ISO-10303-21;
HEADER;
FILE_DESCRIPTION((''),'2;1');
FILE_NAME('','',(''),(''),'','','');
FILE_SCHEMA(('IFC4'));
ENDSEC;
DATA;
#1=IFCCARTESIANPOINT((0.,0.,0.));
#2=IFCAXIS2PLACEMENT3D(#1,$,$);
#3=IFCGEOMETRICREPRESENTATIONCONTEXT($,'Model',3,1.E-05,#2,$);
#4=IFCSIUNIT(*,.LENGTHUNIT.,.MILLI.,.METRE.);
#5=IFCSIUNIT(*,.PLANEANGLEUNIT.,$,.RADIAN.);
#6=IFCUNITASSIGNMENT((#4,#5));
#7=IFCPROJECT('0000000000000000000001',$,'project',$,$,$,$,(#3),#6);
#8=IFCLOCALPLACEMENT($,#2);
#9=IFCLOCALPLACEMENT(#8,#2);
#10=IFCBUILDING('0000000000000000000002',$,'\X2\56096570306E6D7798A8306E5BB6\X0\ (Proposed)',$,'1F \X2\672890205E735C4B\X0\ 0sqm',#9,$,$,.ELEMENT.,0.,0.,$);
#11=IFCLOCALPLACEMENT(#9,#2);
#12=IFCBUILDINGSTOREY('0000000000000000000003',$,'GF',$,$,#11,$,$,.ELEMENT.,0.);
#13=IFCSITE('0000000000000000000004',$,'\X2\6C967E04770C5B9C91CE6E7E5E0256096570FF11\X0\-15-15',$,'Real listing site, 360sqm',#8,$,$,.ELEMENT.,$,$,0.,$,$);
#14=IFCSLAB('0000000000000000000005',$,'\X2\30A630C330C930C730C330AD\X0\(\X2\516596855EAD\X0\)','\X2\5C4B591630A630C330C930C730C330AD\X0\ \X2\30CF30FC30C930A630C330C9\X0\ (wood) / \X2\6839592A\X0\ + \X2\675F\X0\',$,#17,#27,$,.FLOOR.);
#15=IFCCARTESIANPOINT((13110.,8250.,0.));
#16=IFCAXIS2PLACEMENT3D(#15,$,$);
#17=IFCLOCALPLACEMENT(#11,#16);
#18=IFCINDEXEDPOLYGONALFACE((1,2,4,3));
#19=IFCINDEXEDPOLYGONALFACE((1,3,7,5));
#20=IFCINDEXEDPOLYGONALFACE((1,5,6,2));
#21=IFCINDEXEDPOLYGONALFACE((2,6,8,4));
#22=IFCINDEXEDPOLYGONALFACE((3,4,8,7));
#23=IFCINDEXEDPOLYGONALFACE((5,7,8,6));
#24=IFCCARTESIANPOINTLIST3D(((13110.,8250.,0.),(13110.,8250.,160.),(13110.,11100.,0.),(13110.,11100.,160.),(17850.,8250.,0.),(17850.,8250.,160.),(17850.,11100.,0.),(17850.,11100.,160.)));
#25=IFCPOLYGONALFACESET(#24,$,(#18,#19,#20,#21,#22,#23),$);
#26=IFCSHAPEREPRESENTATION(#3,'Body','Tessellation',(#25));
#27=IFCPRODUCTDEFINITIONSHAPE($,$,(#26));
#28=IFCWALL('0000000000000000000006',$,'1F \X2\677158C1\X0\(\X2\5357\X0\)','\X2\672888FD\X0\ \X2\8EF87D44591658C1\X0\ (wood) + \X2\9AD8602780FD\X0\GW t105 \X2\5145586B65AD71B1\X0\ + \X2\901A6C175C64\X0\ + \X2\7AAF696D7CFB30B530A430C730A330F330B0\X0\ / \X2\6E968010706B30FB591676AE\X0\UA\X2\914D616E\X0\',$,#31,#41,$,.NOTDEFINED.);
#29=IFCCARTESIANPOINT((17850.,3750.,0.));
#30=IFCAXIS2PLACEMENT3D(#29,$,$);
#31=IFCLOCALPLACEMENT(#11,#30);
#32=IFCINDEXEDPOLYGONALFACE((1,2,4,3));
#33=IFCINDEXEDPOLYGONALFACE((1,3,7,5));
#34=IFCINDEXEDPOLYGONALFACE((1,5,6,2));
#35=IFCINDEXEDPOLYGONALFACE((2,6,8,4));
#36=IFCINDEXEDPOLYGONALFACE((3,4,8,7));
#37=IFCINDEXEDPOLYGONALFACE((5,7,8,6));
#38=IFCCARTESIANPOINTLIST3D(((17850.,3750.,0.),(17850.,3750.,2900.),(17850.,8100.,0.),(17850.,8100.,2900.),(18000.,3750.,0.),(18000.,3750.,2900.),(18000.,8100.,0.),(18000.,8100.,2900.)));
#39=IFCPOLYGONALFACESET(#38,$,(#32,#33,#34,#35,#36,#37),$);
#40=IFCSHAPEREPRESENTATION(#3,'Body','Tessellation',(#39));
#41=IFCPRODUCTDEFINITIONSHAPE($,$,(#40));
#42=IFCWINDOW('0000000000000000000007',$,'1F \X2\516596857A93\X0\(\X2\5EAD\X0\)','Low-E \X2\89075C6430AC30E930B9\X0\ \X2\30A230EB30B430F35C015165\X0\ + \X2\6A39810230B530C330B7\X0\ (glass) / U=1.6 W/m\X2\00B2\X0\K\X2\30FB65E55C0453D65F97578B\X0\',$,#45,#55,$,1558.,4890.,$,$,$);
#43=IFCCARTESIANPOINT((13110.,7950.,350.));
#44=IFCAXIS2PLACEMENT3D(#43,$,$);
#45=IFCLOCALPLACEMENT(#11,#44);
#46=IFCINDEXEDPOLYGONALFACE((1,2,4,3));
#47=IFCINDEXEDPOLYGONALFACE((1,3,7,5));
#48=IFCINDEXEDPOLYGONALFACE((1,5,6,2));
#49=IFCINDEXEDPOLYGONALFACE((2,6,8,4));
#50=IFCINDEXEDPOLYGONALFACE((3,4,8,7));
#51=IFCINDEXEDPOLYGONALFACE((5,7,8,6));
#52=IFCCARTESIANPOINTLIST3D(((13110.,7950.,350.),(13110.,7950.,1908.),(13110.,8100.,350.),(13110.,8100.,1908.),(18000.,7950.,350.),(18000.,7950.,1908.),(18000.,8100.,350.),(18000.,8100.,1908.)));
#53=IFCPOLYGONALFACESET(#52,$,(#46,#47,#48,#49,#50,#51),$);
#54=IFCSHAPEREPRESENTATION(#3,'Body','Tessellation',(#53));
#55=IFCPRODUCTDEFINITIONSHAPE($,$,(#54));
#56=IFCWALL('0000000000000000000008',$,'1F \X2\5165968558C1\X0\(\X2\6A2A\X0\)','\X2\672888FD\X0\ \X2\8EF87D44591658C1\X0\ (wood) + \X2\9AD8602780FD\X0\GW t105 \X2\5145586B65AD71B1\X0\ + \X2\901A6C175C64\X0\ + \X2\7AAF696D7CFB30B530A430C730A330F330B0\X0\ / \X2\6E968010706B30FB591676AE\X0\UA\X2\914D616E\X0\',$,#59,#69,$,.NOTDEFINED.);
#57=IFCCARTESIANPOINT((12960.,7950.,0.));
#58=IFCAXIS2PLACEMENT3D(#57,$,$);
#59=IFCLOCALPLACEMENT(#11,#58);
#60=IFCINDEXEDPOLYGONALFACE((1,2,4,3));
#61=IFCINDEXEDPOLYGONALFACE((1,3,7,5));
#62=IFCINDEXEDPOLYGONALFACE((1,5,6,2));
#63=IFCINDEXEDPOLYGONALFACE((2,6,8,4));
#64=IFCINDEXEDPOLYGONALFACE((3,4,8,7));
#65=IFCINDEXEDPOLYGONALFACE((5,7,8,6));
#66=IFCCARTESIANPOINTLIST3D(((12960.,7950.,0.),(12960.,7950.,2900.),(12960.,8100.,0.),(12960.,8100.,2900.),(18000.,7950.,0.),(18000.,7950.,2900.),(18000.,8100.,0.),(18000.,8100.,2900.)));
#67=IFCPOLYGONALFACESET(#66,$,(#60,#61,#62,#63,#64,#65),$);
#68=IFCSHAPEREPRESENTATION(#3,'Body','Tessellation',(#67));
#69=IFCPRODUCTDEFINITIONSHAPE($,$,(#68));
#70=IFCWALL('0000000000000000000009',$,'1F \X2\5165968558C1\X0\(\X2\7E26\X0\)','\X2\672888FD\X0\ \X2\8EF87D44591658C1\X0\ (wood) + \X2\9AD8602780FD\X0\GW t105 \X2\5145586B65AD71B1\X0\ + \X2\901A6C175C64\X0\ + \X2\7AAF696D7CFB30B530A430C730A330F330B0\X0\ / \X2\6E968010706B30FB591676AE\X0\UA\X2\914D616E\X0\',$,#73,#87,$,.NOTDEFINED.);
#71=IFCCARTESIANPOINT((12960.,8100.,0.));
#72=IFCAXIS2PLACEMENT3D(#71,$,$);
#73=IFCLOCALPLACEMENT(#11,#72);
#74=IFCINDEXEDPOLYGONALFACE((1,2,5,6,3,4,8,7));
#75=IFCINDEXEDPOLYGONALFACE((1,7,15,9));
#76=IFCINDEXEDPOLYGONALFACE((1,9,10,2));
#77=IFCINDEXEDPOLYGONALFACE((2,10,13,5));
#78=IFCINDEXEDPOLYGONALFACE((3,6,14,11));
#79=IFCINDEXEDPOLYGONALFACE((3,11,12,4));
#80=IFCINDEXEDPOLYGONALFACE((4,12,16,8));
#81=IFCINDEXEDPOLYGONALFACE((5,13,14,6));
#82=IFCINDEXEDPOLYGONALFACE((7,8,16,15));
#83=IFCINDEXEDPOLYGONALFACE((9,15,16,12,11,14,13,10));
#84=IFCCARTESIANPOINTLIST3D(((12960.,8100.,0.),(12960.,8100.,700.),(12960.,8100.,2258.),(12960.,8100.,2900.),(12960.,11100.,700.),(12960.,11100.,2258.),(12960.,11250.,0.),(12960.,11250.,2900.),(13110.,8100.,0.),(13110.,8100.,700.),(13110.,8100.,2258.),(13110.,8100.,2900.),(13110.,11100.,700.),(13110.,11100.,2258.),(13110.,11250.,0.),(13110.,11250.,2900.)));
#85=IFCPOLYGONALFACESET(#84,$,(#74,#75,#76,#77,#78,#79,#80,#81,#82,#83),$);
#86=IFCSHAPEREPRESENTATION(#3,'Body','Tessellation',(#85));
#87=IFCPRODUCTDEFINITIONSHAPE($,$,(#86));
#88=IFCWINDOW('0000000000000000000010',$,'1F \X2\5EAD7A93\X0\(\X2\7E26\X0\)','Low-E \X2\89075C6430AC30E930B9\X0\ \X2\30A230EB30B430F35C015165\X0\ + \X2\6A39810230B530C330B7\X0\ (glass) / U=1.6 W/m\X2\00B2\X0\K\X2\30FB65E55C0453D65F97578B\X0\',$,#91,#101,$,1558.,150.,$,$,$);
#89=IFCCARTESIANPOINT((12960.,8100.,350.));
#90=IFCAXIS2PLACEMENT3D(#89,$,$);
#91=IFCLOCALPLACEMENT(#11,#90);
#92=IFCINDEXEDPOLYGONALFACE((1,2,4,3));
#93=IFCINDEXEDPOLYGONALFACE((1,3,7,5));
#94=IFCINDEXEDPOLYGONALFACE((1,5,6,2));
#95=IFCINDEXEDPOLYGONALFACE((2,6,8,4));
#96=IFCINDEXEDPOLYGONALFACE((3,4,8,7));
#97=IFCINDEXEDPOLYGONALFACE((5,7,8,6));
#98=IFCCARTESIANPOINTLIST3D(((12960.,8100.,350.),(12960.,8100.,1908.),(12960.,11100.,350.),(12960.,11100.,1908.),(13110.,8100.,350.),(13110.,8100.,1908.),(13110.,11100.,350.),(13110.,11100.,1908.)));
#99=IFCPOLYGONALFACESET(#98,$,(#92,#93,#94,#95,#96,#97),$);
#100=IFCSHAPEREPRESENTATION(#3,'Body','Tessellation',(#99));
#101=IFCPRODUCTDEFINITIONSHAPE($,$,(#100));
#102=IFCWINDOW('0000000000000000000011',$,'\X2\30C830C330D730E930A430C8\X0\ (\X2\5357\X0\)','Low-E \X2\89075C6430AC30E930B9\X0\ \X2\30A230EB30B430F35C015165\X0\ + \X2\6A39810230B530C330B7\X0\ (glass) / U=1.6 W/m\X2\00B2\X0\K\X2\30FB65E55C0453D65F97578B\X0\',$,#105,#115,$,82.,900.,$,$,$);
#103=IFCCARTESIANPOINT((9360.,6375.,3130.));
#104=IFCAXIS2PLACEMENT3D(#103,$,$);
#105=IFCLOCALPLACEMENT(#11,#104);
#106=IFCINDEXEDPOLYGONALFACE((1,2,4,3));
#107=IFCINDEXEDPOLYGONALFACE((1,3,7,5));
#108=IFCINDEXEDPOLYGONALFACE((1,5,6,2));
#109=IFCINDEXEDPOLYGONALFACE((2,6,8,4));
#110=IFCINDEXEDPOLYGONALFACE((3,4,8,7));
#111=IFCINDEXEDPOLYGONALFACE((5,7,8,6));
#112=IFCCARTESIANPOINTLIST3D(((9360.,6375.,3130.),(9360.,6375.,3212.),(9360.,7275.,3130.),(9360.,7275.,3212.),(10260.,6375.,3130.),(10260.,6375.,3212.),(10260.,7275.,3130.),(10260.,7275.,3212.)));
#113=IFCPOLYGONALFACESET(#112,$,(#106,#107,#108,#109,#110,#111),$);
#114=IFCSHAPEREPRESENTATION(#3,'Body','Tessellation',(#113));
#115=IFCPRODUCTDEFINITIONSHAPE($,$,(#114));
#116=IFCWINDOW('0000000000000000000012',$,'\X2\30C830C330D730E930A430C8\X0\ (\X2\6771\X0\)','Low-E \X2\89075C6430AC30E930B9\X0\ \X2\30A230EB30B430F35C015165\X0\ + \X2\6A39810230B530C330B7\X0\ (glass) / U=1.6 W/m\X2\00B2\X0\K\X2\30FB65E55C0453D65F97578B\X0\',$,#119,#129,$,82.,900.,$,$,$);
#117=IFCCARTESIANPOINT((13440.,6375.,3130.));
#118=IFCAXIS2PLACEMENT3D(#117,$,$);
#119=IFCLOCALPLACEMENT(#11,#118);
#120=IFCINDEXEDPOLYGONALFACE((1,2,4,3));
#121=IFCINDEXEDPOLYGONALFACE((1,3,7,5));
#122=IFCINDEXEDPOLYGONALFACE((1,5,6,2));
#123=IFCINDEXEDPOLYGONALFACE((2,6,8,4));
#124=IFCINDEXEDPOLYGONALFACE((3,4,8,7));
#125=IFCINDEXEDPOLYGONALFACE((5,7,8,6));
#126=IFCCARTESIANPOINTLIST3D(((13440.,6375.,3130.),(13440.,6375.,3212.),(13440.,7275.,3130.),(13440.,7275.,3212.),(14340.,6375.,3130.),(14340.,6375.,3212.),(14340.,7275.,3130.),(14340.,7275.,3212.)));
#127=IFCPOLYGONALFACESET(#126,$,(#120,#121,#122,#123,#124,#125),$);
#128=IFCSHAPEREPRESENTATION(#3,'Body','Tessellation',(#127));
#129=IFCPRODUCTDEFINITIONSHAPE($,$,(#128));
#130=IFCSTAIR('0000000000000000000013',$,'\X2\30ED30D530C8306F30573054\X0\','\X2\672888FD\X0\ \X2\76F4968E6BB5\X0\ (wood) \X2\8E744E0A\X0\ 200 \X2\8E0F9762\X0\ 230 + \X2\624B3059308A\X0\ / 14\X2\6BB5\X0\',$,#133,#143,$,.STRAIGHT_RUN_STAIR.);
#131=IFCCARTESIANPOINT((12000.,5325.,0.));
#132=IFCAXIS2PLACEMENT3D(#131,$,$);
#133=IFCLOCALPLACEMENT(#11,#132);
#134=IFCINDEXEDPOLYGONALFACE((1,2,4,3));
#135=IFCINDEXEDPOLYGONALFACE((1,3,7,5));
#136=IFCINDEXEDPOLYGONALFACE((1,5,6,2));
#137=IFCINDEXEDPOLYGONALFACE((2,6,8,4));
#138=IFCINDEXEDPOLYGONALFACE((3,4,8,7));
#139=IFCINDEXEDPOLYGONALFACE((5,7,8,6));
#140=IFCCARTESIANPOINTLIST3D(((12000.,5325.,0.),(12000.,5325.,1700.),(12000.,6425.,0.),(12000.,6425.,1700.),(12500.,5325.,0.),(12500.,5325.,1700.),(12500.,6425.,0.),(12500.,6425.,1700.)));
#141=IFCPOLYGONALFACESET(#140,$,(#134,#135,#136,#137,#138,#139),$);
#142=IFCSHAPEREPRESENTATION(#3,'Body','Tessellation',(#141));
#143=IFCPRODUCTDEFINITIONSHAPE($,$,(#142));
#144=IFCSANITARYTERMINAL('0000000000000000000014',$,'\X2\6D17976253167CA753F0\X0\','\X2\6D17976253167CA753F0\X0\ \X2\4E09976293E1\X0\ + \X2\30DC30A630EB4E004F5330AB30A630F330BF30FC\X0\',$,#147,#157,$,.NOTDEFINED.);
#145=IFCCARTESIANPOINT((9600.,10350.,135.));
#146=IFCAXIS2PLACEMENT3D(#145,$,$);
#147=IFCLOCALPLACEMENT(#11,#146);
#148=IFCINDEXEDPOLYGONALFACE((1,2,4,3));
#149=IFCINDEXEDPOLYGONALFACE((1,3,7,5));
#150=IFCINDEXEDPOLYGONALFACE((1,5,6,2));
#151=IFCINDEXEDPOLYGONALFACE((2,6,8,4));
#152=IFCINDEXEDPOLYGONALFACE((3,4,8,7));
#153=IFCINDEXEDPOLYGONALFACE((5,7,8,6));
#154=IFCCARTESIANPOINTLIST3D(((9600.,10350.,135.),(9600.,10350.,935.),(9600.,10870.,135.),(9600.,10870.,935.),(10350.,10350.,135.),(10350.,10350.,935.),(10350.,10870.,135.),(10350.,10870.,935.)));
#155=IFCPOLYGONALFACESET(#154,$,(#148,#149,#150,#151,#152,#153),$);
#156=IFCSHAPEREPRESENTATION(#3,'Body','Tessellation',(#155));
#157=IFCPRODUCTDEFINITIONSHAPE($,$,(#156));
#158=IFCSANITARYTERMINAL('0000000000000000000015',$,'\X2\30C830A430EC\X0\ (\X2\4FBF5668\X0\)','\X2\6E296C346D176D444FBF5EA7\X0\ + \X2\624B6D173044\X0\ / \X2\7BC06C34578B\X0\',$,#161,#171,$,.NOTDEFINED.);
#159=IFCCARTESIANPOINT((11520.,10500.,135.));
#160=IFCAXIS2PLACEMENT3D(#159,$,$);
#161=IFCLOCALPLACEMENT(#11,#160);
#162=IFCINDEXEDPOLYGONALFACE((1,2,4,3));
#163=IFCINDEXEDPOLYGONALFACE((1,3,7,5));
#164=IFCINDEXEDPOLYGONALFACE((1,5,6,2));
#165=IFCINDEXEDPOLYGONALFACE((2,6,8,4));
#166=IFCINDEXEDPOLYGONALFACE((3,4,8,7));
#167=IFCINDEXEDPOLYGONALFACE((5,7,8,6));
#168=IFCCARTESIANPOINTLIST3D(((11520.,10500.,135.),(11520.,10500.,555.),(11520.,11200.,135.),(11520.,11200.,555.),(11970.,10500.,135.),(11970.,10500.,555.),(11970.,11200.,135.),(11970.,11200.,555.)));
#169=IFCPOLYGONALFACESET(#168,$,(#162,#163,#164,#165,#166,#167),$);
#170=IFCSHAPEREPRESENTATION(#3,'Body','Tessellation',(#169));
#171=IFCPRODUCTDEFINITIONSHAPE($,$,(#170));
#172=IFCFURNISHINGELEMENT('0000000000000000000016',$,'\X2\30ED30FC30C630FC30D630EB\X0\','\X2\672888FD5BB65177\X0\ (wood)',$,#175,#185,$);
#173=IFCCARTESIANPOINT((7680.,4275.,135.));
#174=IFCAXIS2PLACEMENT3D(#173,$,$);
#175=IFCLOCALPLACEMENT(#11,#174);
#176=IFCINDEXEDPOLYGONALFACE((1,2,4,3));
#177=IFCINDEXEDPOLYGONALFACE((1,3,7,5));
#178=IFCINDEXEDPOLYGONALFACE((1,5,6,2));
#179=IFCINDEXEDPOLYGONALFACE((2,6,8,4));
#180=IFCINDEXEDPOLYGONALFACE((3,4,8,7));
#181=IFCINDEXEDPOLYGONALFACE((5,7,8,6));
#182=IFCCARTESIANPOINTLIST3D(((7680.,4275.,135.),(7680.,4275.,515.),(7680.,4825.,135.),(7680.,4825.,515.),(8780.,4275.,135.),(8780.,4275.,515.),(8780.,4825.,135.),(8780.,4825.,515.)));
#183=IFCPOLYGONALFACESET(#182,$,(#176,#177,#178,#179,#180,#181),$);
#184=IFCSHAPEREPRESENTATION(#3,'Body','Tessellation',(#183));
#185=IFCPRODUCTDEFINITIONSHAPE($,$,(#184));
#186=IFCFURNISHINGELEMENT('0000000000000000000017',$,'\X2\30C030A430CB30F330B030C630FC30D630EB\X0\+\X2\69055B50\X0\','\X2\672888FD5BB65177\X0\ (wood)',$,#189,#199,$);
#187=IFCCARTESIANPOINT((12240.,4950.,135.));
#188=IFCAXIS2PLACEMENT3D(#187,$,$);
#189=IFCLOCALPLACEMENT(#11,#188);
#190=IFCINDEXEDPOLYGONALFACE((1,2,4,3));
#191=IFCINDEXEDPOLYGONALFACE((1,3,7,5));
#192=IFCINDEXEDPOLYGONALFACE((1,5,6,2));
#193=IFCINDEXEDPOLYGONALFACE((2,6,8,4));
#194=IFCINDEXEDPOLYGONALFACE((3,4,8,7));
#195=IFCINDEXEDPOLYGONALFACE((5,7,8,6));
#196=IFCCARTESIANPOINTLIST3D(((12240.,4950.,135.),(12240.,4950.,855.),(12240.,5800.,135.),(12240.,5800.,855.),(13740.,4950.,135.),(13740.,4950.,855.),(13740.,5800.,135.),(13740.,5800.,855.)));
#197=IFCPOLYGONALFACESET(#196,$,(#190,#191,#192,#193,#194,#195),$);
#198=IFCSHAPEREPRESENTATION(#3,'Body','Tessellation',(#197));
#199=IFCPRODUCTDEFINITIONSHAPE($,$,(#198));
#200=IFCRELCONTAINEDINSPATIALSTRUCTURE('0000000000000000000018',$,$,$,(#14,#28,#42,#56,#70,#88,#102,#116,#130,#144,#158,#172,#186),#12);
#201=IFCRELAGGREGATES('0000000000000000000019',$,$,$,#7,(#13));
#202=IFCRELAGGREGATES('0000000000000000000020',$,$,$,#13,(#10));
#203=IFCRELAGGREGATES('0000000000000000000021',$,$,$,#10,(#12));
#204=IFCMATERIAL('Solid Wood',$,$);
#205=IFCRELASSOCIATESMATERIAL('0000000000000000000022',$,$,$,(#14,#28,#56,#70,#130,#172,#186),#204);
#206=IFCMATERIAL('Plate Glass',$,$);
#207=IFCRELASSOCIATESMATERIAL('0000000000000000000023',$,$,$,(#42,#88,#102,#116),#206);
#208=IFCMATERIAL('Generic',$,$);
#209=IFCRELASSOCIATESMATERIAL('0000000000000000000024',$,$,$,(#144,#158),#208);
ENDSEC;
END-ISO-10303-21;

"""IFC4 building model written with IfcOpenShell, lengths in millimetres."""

from ifc_helpers import new_model, si_unit, frame, frame_2d, origin, place, context, project, spatial, rectangle, extrude, material, element, fill, save


model = new_model("IFC4")

# Units and contexts
model_context = context("Model", 3, precision=1e-05, world=origin())
ifc_project = project(units=[si_unit("LENGTHUNIT", "METRE", prefix="MILLI"), si_unit("PLANEANGLEUNIT", "RADIAN")], contexts=[model_context])

# Site, building, storey
site_placement = place(None, origin())
site = spatial("IfcSite", under=ifc_project, at=site_placement, Name="沖縄県宜野湾市嘉数１-15-15", ObjectType="Real listing site, 360sqm", CompositionType="ELEMENT", RefElevation=0.0)
building_placement = place(site_placement, origin())
building = spatial("IfcBuilding", under=site, at=building_placement, Name="嘉数の海風の家 (Proposed)", ObjectType="1F 木造平屋 0sqm", CompositionType="ELEMENT", ElevationOfRefHeight=0.0, ElevationOfTerrain=0.0)
storey_placement = place(building_placement, origin())
storey = spatial("IfcBuildingStorey", under=building, at=storey_placement, Name="GF", CompositionType="ELEMENT", Elevation=0.0)

# Slab
ifc_material_1 = material(Name="Solid Wood")
slab_placement = place(storey_placement, frame((13110.0, 8250.0, 0.0)))
element("IfcSlab", 1, at=slab_placement, inside=storey, material=ifc_material_1, Name="ウッドデッキ(入隅庭)", Description="屋外ウッドデッキ ハードウッド (wood) / 根太 + 束", PredefinedType="FLOOR", context=model_context, shape_type="SweptSolid", body=[
    extrude(rectangle(XDim=4740.0, YDim=2850.0, at=frame_2d((2370.0, 1425.0))), frame((13110.0, 8250.0, 0.0)), (0.0, 0.0, 1.0), 160.0),
])

# Wall, opening, window
wall_1_placement = place(storey_placement, frame((17850.0, 3750.0, 0.0)))
wall_1 = element("IfcWall", 2, at=wall_1_placement, inside=storey, material=ifc_material_1, Name="1F 東壁(南)", Description="木製 軸組外壁 (wood) + 高性能GW t105 充填断熱 + 通気層 + 窯業系サイディング / 準耐火・外皮UA配慮", PredefinedType="NOTDEFINED", context=model_context, shape_type="SweptSolid", body=[
    extrude(rectangle(XDim=150.0, YDim=4350.0, at=frame_2d((75.0, 2175.0))), frame((17850.0, 3750.0, 0.0)), (0.0, 0.0, 1.0), 2900.0),
])
opening_1_placement = place(storey_placement, frame((13110.0, 7950.0, 350.0)))
opening_1 = element("IfcOpeningElement", 3, at=opening_1_placement, cuts=wall_1, PredefinedType="NOTDEFINED", context=model_context, shape_type="SweptSolid", body=[
    extrude(rectangle(XDim=4890.0, YDim=150.0, at=frame_2d((2445.0, 75.0))), frame((13110.0, 7950.0, 350.0)), (0.0, 0.0, 1.0), 1558.0),
])
ifc_material_2 = material(Name="Plate Glass")
window_1_placement = place(storey_placement, frame((13110.0, 7950.0, 350.0)))
window_1 = element("IfcWindow", 4, at=window_1_placement, inside=storey, material=ifc_material_2, Name="1F 入隅窓(庭)", Description="Low-E 複層ガラス アルゴン封入 + 樹脂サッシ (glass) / U=1.6 W/m²K・日射取得型", OverallHeight=1558.0, OverallWidth=4890.0, context=model_context, shape_type="SweptSolid", body=[
    extrude(rectangle(XDim=4890.0, YDim=150.0, at=frame_2d((2445.0, 75.0))), frame((13110.0, 7950.0, 350.0)), (0.0, 0.0, 1.0), 1558.0),
])
fill(opening_1, window_1)

# Wall
wall_2_placement = place(storey_placement, frame((12960.0, 7950.0, 0.0)))
element("IfcWall", 5, at=wall_2_placement, inside=storey, material=ifc_material_1, Name="1F 入隅壁(横)", Description="木製 軸組外壁 (wood) + 高性能GW t105 充填断熱 + 通気層 + 窯業系サイディング / 準耐火・外皮UA配慮", PredefinedType="NOTDEFINED", context=model_context, shape_type="SweptSolid", body=[
    extrude(rectangle(XDim=5040.0, YDim=150.0, at=frame_2d((2520.0, 75.0))), frame((12960.0, 7950.0, 0.0)), (0.0, 0.0, 1.0), 2900.0),
])

# Wall, opening, window
wall_3_placement = place(storey_placement, frame((12960.0, 8100.0, 0.0)))
wall_3 = element("IfcWall", 6, at=wall_3_placement, inside=storey, material=ifc_material_1, Name="1F 入隅壁(縦)", Description="木製 軸組外壁 (wood) + 高性能GW t105 充填断熱 + 通気層 + 窯業系サイディング / 準耐火・外皮UA配慮", PredefinedType="NOTDEFINED", context=model_context, shape_type="SweptSolid", body=[
    extrude(rectangle(XDim=150.0, YDim=3150.0, at=frame_2d((75.0, 1575.0))), frame((12960.0, 8100.0, 0.0)), (0.0, 0.0, 1.0), 2900.0),
])
opening_2_placement = place(storey_placement, frame((12960.0, 8100.0, 350.0)))
opening_2 = element("IfcOpeningElement", 7, at=opening_2_placement, cuts=wall_3, PredefinedType="NOTDEFINED", context=model_context, shape_type="SweptSolid", body=[
    extrude(rectangle(XDim=150.0, YDim=3000.0, at=frame_2d((75.0, 1500.0))), frame((12960.0, 8100.0, 350.0)), (0.0, 0.0, 1.0), 1558.0),
])
window_2_placement = place(storey_placement, frame((12960.0, 8100.0, 350.0)))
window_2 = element("IfcWindow", 8, at=window_2_placement, inside=storey, material=ifc_material_2, Name="1F 庭窓(縦)", Description="Low-E 複層ガラス アルゴン封入 + 樹脂サッシ (glass) / U=1.6 W/m²K・日射取得型", OverallHeight=1558.0, OverallWidth=150.0, context=model_context, shape_type="SweptSolid", body=[
    extrude(rectangle(XDim=150.0, YDim=3000.0, at=frame_2d((75.0, 1500.0))), frame((12960.0, 8100.0, 350.0)), (0.0, 0.0, 1.0), 1558.0),
])
fill(opening_2, window_2)

# Windows
window_3_placement = place(storey_placement, frame((9360.0, 6375.0, 3130.0)))
element("IfcWindow", 9, at=window_3_placement, inside=storey, material=ifc_material_2, Name="トップライト (南)", Description="Low-E 複層ガラス アルゴン封入 + 樹脂サッシ (glass) / U=1.6 W/m²K・日射取得型", OverallHeight=82.0, OverallWidth=900.0, context=model_context, shape_type="SweptSolid", body=[
    extrude(rectangle(XDim=900.0, YDim=900.0, at=frame_2d((450.0, 450.0))), frame((9360.0, 6375.0, 3130.0)), (0.0, 0.0, 1.0), 82.0),
])
window_4_placement = place(storey_placement, frame((13440.0, 6375.0, 3130.0)))
element("IfcWindow", 10, at=window_4_placement, inside=storey, material=ifc_material_2, Name="トップライト (東)", Description="Low-E 複層ガラス アルゴン封入 + 樹脂サッシ (glass) / U=1.6 W/m²K・日射取得型", OverallHeight=82.0, OverallWidth=900.0, context=model_context, shape_type="SweptSolid", body=[
    extrude(rectangle(XDim=900.0, YDim=900.0, at=frame_2d((450.0, 450.0))), frame((13440.0, 6375.0, 3130.0)), (0.0, 0.0, 1.0), 82.0),
])

# Stair
stair_placement = place(storey_placement, frame((12000.0, 5325.0, 0.0)))
element("IfcStair", 11, at=stair_placement, inside=storey, material=ifc_material_1, Name="ロフトはしご", Description="木製 直階段 (wood) 蹴上 200 踏面 230 + 手すり / 14段", PredefinedType="STRAIGHT_RUN_STAIR", context=model_context, shape_type="SweptSolid", body=[
    extrude(rectangle(XDim=500.0, YDim=1100.0, at=frame_2d((250.0, 550.0))), frame((12000.0, 5325.0, 0.0)), (0.0, 0.0, 1.0), 1700.0),
])

# Sanitary terminals
ifc_material_3 = material(Name="Generic")
sanitary_terminal_1_placement = place(storey_placement, frame((9600.0, 10350.0, 135.0)))
element("IfcSanitaryTerminal", 12, at=sanitary_terminal_1_placement, inside=storey, material=ifc_material_3, Name="洗面化粧台", Description="洗面化粧台 三面鏡 + ボウル一体カウンター", PredefinedType="NOTDEFINED", context=model_context, shape_type="SweptSolid", body=[
    extrude(rectangle(XDim=750.0, YDim=520.0, at=frame_2d((375.0, 260.0))), frame((9600.0, 10350.0, 135.0)), (0.0, 0.0, 1.0), 800.0),
])
sanitary_terminal_2_placement = place(storey_placement, frame((11520.0, 10500.0, 135.0)))
element("IfcSanitaryTerminal", 13, at=sanitary_terminal_2_placement, inside=storey, material=ifc_material_3, Name="トイレ (便器)", Description="温水洗浄便座 + 手洗い / 節水型", PredefinedType="NOTDEFINED", context=model_context, shape_type="SweptSolid", body=[
    extrude(rectangle(XDim=450.0, YDim=700.0, at=frame_2d((225.0, 350.0))), frame((11520.0, 10500.0, 135.0)), (0.0, 0.0, 1.0), 420.0),
])

# Furnishing elements
furnishing_1_placement = place(storey_placement, frame((7680.0, 4275.0, 135.0)))
element("IfcFurnishingElement", 14, at=furnishing_1_placement, inside=storey, material=ifc_material_1, Name="ローテーブル", Description="木製家具 (wood)", context=model_context, shape_type="SweptSolid", body=[
    extrude(rectangle(XDim=1100.0, YDim=550.0, at=frame_2d((550.0, 275.0))), frame((7680.0, 4275.0, 135.0)), (0.0, 0.0, 1.0), 380.0),
])
furnishing_2_placement = place(storey_placement, frame((12240.0, 4950.0, 135.0)))
element("IfcFurnishingElement", 15, at=furnishing_2_placement, inside=storey, material=ifc_material_1, Name="ダイニングテーブル+椅子", Description="木製家具 (wood)", context=model_context, shape_type="SweptSolid", body=[
    extrude(rectangle(XDim=1500.0, YDim=850.0, at=frame_2d((750.0, 425.0))), frame((12240.0, 4950.0, 135.0)), (0.0, 0.0, 1.0), 720.0),
])

save(model, "model.ifc")
